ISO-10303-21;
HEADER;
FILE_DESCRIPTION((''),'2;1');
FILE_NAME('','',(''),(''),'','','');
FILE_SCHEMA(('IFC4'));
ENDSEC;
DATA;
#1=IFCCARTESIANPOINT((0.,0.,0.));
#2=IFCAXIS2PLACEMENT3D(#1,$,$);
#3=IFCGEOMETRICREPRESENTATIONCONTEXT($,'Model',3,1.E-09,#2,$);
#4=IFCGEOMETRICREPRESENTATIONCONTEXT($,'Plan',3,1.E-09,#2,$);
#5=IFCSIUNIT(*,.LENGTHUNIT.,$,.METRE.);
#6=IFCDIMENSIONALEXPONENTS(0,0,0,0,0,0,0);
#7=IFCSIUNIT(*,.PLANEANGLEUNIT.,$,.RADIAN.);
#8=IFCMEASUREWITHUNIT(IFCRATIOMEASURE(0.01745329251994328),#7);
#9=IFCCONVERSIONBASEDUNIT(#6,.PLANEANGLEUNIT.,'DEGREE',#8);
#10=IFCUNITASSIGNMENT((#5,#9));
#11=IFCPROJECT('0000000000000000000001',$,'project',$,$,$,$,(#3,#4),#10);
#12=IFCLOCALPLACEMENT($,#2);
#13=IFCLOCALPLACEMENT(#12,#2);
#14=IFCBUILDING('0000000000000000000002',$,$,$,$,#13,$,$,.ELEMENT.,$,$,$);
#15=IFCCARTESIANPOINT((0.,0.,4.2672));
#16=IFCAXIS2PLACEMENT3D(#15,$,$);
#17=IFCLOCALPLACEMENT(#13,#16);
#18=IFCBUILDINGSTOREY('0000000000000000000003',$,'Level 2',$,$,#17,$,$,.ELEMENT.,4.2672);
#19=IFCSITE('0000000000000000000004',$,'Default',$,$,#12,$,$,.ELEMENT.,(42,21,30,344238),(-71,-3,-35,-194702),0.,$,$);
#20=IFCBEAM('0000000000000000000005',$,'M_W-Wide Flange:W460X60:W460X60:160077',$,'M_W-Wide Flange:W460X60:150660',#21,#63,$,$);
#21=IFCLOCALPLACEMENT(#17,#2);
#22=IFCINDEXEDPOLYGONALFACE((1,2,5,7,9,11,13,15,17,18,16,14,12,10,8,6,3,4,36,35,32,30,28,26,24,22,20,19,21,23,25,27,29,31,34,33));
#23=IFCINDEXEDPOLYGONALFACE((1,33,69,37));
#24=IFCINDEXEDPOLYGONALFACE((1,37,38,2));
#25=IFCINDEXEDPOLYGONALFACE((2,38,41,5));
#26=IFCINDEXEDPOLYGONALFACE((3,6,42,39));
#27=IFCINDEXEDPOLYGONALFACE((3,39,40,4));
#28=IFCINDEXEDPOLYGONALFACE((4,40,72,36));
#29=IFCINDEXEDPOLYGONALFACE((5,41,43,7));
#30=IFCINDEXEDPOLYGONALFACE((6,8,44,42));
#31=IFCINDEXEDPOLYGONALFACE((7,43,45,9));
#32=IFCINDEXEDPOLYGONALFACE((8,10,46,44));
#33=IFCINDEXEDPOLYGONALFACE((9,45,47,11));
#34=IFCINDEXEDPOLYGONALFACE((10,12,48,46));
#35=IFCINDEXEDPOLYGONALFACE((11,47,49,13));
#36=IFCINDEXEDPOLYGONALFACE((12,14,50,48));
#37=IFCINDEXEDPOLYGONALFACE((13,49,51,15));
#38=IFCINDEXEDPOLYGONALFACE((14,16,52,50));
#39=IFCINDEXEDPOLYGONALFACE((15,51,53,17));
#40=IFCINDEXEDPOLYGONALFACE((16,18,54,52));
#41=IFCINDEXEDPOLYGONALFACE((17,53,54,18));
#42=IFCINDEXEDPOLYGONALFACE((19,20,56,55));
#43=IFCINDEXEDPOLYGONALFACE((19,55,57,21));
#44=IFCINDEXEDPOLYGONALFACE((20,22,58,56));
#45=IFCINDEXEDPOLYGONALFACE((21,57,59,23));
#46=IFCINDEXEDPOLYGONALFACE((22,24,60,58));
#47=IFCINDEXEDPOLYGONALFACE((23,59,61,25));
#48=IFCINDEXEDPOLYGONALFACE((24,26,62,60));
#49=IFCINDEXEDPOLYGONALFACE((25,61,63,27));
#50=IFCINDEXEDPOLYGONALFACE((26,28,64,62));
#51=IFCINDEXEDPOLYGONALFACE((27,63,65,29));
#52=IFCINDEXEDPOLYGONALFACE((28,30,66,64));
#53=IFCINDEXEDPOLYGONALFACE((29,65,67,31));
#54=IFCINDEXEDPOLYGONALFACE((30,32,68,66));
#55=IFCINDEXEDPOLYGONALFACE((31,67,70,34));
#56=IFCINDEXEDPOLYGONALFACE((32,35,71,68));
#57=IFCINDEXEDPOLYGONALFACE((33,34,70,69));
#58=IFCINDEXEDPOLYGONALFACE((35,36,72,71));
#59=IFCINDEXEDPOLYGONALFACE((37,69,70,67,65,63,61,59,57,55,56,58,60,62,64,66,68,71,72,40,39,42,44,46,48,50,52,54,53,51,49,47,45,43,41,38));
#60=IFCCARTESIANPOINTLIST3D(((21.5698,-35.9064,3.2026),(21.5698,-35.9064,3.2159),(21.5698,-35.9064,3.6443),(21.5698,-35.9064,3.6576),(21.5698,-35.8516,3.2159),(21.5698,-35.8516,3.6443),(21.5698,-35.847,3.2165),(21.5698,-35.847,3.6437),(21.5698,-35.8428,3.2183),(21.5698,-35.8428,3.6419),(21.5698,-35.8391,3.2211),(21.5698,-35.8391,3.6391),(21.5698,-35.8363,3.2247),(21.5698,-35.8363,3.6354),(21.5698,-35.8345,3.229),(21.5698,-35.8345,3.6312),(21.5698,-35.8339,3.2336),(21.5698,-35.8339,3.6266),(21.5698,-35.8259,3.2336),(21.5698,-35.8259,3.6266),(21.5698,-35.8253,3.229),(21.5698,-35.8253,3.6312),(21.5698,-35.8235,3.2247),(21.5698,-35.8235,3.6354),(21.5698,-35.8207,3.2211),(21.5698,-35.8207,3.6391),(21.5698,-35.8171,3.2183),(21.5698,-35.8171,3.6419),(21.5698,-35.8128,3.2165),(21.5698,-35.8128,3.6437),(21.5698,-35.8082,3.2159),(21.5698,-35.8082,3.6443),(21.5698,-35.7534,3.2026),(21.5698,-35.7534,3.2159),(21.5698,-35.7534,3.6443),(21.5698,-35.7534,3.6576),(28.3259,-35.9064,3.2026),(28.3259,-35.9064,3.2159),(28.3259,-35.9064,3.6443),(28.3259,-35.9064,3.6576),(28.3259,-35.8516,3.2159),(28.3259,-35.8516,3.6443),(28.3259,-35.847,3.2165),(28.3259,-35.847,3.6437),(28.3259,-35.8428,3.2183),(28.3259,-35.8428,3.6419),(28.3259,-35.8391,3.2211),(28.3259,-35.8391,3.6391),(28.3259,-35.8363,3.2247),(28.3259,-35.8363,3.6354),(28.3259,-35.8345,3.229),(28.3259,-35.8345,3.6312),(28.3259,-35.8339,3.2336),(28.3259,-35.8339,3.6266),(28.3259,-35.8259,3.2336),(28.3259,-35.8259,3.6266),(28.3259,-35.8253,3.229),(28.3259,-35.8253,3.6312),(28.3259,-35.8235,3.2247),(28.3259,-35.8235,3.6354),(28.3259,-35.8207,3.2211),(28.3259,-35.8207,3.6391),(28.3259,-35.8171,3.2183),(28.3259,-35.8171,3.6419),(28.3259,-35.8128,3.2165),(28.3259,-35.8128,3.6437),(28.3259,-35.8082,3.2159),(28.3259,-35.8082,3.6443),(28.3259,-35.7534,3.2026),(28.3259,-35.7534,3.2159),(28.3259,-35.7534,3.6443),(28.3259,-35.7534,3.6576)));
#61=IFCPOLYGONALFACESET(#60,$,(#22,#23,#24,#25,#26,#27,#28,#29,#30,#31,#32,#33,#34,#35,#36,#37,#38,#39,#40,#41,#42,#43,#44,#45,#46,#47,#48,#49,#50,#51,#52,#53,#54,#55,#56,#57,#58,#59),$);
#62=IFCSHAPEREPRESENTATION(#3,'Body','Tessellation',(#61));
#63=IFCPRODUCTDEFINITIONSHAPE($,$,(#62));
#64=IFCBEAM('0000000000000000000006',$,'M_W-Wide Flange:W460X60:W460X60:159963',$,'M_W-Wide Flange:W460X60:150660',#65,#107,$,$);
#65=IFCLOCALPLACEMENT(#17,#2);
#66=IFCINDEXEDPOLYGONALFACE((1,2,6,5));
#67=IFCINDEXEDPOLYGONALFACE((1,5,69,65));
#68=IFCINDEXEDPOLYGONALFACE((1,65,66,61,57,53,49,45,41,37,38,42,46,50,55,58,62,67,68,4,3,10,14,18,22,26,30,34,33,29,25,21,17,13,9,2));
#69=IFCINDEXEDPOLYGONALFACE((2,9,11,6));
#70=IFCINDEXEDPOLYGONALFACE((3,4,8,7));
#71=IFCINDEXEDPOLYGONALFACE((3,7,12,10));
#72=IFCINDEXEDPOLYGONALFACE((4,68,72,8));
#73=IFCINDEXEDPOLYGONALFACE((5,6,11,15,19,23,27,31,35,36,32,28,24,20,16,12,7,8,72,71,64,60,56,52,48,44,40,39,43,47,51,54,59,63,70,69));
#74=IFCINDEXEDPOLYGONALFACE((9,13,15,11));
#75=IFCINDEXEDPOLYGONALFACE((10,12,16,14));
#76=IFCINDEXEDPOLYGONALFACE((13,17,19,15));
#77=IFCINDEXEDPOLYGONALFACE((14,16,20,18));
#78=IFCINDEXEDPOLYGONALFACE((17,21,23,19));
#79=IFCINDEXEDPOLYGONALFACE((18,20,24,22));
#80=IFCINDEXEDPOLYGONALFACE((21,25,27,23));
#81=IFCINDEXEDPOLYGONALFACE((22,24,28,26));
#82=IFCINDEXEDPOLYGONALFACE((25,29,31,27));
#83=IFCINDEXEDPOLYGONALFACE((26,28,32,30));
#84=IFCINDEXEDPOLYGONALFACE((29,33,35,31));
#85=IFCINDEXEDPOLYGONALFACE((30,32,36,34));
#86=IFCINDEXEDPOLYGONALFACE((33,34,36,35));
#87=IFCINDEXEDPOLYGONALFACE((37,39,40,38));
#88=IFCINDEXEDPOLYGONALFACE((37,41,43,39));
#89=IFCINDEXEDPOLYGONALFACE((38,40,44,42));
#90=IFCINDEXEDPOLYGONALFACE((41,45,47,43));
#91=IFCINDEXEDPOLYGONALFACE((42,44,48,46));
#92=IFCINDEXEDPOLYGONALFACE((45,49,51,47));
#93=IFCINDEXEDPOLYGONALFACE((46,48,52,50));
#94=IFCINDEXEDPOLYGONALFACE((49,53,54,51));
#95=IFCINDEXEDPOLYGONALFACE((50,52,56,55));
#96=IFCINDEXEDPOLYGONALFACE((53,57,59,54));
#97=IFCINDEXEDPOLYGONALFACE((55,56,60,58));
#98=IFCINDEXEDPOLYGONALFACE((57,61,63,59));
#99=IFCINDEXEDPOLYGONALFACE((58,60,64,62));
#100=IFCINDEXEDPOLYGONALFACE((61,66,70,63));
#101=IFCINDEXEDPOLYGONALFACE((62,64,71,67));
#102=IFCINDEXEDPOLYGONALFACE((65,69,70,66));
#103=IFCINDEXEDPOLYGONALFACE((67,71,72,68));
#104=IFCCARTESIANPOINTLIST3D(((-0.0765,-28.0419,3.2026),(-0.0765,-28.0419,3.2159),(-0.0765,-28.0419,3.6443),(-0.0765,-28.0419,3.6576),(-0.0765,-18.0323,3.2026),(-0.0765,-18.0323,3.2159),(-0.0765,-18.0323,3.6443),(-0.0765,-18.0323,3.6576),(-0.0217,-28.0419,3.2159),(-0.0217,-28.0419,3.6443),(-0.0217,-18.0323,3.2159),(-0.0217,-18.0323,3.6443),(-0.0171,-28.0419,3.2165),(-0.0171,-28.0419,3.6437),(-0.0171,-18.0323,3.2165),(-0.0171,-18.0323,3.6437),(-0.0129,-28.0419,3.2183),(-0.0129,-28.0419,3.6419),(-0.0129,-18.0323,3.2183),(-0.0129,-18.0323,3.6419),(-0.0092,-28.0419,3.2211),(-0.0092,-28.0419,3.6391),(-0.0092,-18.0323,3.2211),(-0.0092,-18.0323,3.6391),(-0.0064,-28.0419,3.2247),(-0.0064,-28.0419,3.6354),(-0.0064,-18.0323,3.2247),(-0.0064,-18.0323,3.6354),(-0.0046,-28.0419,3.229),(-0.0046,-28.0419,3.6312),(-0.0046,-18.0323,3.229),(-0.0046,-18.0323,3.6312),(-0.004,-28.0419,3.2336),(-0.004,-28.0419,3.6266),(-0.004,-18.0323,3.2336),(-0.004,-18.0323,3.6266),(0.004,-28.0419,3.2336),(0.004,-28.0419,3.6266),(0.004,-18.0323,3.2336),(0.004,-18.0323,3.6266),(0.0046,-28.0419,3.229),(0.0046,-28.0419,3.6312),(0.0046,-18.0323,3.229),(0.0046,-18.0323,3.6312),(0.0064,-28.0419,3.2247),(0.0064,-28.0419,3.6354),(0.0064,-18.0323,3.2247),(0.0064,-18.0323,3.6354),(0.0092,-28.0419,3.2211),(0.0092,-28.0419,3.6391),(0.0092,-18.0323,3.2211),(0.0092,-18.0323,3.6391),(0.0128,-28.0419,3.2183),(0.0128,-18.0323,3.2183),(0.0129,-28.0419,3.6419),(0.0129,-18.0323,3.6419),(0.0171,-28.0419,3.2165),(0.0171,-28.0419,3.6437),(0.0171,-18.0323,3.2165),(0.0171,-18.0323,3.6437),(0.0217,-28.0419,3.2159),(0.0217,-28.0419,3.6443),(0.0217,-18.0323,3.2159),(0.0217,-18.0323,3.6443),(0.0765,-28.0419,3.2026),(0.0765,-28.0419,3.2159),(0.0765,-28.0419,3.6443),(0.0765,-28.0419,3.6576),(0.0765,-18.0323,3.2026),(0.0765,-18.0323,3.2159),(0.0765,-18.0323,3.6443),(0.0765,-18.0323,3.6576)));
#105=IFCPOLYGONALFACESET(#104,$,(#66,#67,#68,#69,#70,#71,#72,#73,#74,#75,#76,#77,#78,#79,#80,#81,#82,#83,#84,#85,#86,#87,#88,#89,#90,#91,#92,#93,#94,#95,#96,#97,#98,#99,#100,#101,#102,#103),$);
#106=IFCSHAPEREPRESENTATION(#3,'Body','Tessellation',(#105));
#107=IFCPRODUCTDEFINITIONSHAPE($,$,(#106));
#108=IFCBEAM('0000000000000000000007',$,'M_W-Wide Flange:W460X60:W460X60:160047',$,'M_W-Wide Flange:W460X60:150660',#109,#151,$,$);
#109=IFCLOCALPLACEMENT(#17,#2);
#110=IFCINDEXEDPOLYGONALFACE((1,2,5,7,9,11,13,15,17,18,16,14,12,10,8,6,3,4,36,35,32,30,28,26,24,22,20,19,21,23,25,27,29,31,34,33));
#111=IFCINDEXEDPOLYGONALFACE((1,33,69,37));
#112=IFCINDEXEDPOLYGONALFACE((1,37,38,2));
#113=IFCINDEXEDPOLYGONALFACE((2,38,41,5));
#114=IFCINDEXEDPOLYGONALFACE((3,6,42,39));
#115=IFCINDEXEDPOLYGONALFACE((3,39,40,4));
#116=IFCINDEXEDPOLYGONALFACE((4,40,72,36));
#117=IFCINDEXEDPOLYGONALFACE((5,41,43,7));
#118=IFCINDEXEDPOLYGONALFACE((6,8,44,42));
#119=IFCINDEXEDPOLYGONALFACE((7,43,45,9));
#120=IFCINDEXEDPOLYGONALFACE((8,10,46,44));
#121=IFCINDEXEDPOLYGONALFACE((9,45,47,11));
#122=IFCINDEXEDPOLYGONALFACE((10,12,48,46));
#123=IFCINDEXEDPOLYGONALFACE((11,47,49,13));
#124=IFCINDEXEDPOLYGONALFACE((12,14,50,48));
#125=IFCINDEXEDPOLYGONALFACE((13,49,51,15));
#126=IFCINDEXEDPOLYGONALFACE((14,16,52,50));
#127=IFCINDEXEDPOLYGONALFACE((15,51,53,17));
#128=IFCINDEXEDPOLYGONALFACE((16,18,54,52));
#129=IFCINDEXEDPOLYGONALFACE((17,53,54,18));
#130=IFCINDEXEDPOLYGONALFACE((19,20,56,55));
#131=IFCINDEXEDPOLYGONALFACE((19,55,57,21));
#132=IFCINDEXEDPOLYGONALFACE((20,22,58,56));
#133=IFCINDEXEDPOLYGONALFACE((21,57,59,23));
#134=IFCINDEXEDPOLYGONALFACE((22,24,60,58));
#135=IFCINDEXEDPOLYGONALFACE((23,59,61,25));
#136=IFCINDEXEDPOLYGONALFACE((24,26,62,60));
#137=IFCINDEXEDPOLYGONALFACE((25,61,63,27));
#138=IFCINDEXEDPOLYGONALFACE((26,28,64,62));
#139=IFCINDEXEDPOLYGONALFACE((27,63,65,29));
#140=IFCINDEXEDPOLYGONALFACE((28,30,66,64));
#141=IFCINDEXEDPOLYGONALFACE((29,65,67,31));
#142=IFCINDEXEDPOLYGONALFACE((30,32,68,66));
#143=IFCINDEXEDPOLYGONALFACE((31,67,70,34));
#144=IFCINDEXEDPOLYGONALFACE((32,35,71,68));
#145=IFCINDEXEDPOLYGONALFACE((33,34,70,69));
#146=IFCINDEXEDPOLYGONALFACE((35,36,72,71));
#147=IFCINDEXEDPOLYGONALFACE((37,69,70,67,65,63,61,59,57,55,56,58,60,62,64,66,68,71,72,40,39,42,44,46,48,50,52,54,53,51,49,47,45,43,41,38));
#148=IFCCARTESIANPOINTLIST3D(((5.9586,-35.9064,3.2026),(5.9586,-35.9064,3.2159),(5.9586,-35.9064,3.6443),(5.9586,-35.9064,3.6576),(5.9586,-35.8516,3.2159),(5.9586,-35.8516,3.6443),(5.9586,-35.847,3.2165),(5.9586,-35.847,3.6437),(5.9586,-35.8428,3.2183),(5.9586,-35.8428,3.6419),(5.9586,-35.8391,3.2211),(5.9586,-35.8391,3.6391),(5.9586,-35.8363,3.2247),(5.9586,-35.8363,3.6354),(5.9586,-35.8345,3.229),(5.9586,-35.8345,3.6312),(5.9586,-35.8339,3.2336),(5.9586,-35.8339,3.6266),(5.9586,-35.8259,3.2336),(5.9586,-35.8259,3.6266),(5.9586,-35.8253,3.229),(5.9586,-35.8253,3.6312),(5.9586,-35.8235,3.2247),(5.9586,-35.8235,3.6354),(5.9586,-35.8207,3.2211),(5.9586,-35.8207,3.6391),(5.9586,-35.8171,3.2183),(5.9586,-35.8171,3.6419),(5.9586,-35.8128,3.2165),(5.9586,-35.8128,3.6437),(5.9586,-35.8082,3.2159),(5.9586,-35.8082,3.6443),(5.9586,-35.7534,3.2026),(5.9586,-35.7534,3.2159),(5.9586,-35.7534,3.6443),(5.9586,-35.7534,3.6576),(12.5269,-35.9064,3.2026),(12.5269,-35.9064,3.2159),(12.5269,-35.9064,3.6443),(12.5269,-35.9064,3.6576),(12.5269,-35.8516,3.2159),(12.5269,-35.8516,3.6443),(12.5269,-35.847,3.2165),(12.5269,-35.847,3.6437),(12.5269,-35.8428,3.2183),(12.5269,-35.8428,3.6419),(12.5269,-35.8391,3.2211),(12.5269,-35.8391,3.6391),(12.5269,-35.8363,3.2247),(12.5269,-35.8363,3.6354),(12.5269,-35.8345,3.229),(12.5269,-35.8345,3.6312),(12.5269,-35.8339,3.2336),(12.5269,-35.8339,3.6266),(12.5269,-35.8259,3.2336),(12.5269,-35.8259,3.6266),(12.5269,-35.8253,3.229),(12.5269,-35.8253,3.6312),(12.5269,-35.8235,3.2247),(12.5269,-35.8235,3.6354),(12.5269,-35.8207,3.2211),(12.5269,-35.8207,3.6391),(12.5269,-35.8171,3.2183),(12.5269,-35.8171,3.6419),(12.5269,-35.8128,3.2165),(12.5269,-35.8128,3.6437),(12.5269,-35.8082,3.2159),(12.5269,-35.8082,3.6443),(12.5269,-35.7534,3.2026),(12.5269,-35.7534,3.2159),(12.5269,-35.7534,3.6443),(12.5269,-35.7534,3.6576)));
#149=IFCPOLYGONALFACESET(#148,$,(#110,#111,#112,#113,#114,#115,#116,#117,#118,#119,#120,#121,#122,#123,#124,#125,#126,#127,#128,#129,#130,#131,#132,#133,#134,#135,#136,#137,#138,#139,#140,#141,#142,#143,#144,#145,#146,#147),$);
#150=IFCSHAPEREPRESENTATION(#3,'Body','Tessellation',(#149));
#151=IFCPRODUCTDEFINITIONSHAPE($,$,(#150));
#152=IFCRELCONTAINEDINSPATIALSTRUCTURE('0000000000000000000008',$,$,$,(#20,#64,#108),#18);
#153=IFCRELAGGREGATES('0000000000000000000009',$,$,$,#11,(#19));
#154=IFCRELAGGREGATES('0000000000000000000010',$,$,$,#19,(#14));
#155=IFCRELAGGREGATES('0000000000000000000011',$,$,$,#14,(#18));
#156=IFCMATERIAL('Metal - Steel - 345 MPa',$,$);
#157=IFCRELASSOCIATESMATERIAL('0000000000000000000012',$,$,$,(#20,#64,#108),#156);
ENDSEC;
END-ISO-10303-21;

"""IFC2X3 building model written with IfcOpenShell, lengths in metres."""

from ifc_helpers import new_model, entity, si_unit, converted_unit, frame, frame_2d, origin, place, context, project, spatial, polyline, circle_curve, parameter, trimmed, segment, composite_curve, outline, extrude, material, element, save


model = new_model("IFC2X3")

# Units and contexts
model_context = context("Model", 3, precision=1e-09, world=origin())
plan_context = context("Plan", 3, precision=1e-09, world=origin())
ifc_project = project(units=[si_unit("LENGTHUNIT", "METRE"), converted_unit("PLANEANGLEUNIT", "DEGREE", entity("IfcRatioMeasure", 0.01745329251994328), si_unit("PLANEANGLEUNIT", "RADIAN"), dimensions=[0, 0, 0, 0, 0, 0, 0])], contexts=[model_context, plan_context])

# Site, building, storey
site_placement = place(None, origin())
site = spatial("IfcSite", under=ifc_project, at=site_placement, Name="Default", CompositionType="ELEMENT", RefLatitude=(42, 21, 30, 344238), RefLongitude=(-71, -3, -35, -194702), RefElevation=0.0)
building_placement = place(site_placement, origin())
building = spatial("IfcBuilding", under=site, at=building_placement, CompositionType="ELEMENT")
storey_placement = place(building_placement, frame((0.0, 0.0, 4.2672)))
storey = spatial("IfcBuildingStorey", under=building, at=storey_placement, Name="Level 2", CompositionType="ELEMENT", Elevation=4.2672)

# Shared definitions
ifc_material_1 = material(Name="Metal - Steel - 345 MPa")

# Beams
beam_1_placement = place(storey_placement, frame((21.4678, -35.8299, 3.6576), z_axis=(0.0, 0.0, 1.0), x_axis=(0.0, -1.0, 0.0)))
element("IfcBeam", 1, at=beam_1_placement, inside=storey, material=ifc_material_1, Name="M_W-Wide Flange:W460X60:W460X60:160077", ObjectType="M_W-Wide Flange:W460X60:150660", context=model_context, shape_type="SweptSolid", body=[
    extrude(outline(composite_curve([segment(polyline([(-0.0765, -0.2142), (-0.0765, -0.2275)]), True, "CONTINUOUS"), segment(polyline([(-0.0765, -0.2275), (0.0765, -0.2275)]), True, "CONTINUOUS"), segment(polyline([(0.0765, -0.2275), (0.0765, -0.2142)]), True, "CONTINUOUS"), segment(polyline([(0.0765, -0.2142), (0.0217, -0.2142)]), True, "CONTINUOUS"), segment(trimmed(circle_curve(frame_2d((0.0217, -0.1965), x_axis=(0.0, -1.0)), 0.0177), [parameter(270.0)], [parameter(360.0)], True, "PARAMETER"), False, "CONTINUOUS"), segment(polyline([(0.004, -0.1965), (0.004, 0.1965)]), True, "CONTINUOUS"), segment(trimmed(circle_curve(frame_2d((0.0217, 0.1965), x_axis=(-1.0, 0.0)), 0.0177), [parameter(270.0)], [parameter(360.0)], True, "PARAMETER"), False, "CONTINUOUS"), segment(polyline([(0.0217, 0.2142), (0.0765, 0.2142)]), True, "CONTINUOUS"), segment(polyline([(0.0765, 0.2142), (0.0765, 0.2275)]), True, "CONTINUOUS"), segment(polyline([(0.0765, 0.2275), (-0.0765, 0.2275)]), True, "CONTINUOUS"), segment(polyline([(-0.0765, 0.2275), (-0.0765, 0.2142)]), True, "CONTINUOUS"), segment(polyline([(-0.0765, 0.2142), (-0.0217, 0.2142)]), True, "CONTINUOUS"), segment(trimmed(circle_curve(frame_2d((-0.0217, 0.1965), x_axis=(0.0, 1.0)), 0.0177), [parameter(270.0)], [parameter(360.0)], True, "PARAMETER"), False, "CONTINUOUS"), segment(polyline([(-0.004, 0.1965), (-0.004, -0.1965)]), True, "CONTINUOUS"), segment(trimmed(circle_curve(frame_2d((-0.0217, -0.1965), x_axis=(1.0, 0.0)), 0.0177), [parameter(270.0)], [parameter(0.0)], True, "PARAMETER"), False, "CONTINUOUS"), segment(polyline([(-0.0217, -0.2142), (-0.0765, -0.2142)]), True, "CONTINUOUS")], self_intersect=False)), frame((0.0, 0.102, -0.2275), z_axis=(0.0, -1.0, 0.0), x_axis=(1.0, 0.0, 0.0)), (0.0, 0.0, -1.0), 6.7561),
])
beam_2_placement = place(storey_placement, frame((0.0, -28.1704, 3.6576)))
element("IfcBeam", 2, at=beam_2_placement, inside=storey, material=ifc_material_1, Name="M_W-Wide Flange:W460X60:W460X60:159963", ObjectType="M_W-Wide Flange:W460X60:150660", context=model_context, shape_type="SweptSolid", body=[
    extrude(outline(composite_curve([segment(polyline([(-0.0765, -0.2142), (-0.0765, -0.2275)]), True, "CONTINUOUS"), segment(polyline([(-0.0765, -0.2275), (0.0765, -0.2275)]), True, "CONTINUOUS"), segment(polyline([(0.0765, -0.2275), (0.0765, -0.2142)]), True, "CONTINUOUS"), segment(polyline([(0.0765, -0.2142), (0.0217, -0.2142)]), True, "CONTINUOUS"), segment(trimmed(circle_curve(frame_2d((0.0217, -0.1965), x_axis=(0.0, -1.0)), 0.0177), [parameter(270.0)], [parameter(360.0)], True, "PARAMETER"), False, "CONTINUOUS"), segment(polyline([(0.004, -0.1965), (0.004, 0.1965)]), True, "CONTINUOUS"), segment(trimmed(circle_curve(frame_2d((0.0217, 0.1965), x_axis=(-1.0, 0.0)), 0.0177), [parameter(270.0)], [parameter(360.0)], True, "PARAMETER"), False, "CONTINUOUS"), segment(polyline([(0.0217, 0.2142), (0.0765, 0.2142)]), True, "CONTINUOUS"), segment(polyline([(0.0765, 0.2142), (0.0765, 0.2275)]), True, "CONTINUOUS"), segment(polyline([(0.0765, 0.2275), (-0.0765, 0.2275)]), True, "CONTINUOUS"), segment(polyline([(-0.0765, 0.2275), (-0.0765, 0.2142)]), True, "CONTINUOUS"), segment(polyline([(-0.0765, 0.2142), (-0.0217, 0.2142)]), True, "CONTINUOUS"), segment(trimmed(circle_curve(frame_2d((-0.0217, 0.1965), x_axis=(0.0, 1.0)), 0.0177), [parameter(270.0)], [parameter(360.0)], True, "PARAMETER"), False, "CONTINUOUS"), segment(polyline([(-0.004, 0.1965), (-0.004, -0.1965)]), True, "CONTINUOUS"), segment(trimmed(circle_curve(frame_2d((-0.0217, -0.1965), x_axis=(1.0, 0.0)), 0.0177), [parameter(270.0)], [parameter(0.0)], True, "PARAMETER"), False, "CONTINUOUS"), segment(polyline([(-0.0217, -0.2142), (-0.0765, -0.2142)]), True, "CONTINUOUS")], self_intersect=False)), frame((0.0, 0.1285, -0.2275), z_axis=(0.0, -1.0, 0.0), x_axis=(1.0, 0.0, 0.0)), (0.0, 0.0, -1.0), 10.0095),
])
beam_3_placement = place(storey_placement, frame((5.8566, -35.8299, 3.6576), z_axis=(0.0, 0.0, 1.0), x_axis=(0.0, -1.0, 0.0)))
element("IfcBeam", 3, at=beam_3_placement, inside=storey, material=ifc_material_1, Name="M_W-Wide Flange:W460X60:W460X60:160047", ObjectType="M_W-Wide Flange:W460X60:150660", context=model_context, shape_type="SweptSolid", body=[
    extrude(outline(composite_curve([segment(polyline([(-0.0765, -0.2142), (-0.0765, -0.2275)]), True, "CONTINUOUS"), segment(polyline([(-0.0765, -0.2275), (0.0765, -0.2275)]), True, "CONTINUOUS"), segment(polyline([(0.0765, -0.2275), (0.0765, -0.2142)]), True, "CONTINUOUS"), segment(polyline([(0.0765, -0.2142), (0.0217, -0.2142)]), True, "CONTINUOUS"), segment(trimmed(circle_curve(frame_2d((0.0217, -0.1965), x_axis=(0.0, -1.0)), 0.0177), [parameter(270.0)], [parameter(360.0)], True, "PARAMETER"), False, "CONTINUOUS"), segment(polyline([(0.004, -0.1965), (0.004, 0.1965)]), True, "CONTINUOUS"), segment(trimmed(circle_curve(frame_2d((0.0217, 0.1965), x_axis=(-1.0, 0.0)), 0.0177), [parameter(270.0)], [parameter(360.0)], True, "PARAMETER"), False, "CONTINUOUS"), segment(polyline([(0.0217, 0.2142), (0.0765, 0.2142)]), True, "CONTINUOUS"), segment(polyline([(0.0765, 0.2142), (0.0765, 0.2275)]), True, "CONTINUOUS"), segment(polyline([(0.0765, 0.2275), (-0.0765, 0.2275)]), True, "CONTINUOUS"), segment(polyline([(-0.0765, 0.2275), (-0.0765, 0.2142)]), True, "CONTINUOUS"), segment(polyline([(-0.0765, 0.2142), (-0.0217, 0.2142)]), True, "CONTINUOUS"), segment(trimmed(circle_curve(frame_2d((-0.0217, 0.1965), x_axis=(0.0, 1.0)), 0.0177), [parameter(270.0)], [parameter(360.0)], True, "PARAMETER"), False, "CONTINUOUS"), segment(polyline([(-0.004, 0.1965), (-0.004, -0.1965)]), True, "CONTINUOUS"), segment(trimmed(circle_curve(frame_2d((-0.0217, -0.1965), x_axis=(1.0, 0.0)), 0.0177), [parameter(270.0)], [parameter(0.0)], True, "PARAMETER"), False, "CONTINUOUS"), segment(polyline([(-0.0217, -0.2142), (-0.0765, -0.2142)]), True, "CONTINUOUS")], self_intersect=False)), frame((0.0, 0.102, -0.2275), z_axis=(0.0, -1.0, 0.0), x_axis=(1.0, 0.0, 0.0)), (0.0, 0.0, -1.0), 6.5683),
])

save(model, "model.ifc")
